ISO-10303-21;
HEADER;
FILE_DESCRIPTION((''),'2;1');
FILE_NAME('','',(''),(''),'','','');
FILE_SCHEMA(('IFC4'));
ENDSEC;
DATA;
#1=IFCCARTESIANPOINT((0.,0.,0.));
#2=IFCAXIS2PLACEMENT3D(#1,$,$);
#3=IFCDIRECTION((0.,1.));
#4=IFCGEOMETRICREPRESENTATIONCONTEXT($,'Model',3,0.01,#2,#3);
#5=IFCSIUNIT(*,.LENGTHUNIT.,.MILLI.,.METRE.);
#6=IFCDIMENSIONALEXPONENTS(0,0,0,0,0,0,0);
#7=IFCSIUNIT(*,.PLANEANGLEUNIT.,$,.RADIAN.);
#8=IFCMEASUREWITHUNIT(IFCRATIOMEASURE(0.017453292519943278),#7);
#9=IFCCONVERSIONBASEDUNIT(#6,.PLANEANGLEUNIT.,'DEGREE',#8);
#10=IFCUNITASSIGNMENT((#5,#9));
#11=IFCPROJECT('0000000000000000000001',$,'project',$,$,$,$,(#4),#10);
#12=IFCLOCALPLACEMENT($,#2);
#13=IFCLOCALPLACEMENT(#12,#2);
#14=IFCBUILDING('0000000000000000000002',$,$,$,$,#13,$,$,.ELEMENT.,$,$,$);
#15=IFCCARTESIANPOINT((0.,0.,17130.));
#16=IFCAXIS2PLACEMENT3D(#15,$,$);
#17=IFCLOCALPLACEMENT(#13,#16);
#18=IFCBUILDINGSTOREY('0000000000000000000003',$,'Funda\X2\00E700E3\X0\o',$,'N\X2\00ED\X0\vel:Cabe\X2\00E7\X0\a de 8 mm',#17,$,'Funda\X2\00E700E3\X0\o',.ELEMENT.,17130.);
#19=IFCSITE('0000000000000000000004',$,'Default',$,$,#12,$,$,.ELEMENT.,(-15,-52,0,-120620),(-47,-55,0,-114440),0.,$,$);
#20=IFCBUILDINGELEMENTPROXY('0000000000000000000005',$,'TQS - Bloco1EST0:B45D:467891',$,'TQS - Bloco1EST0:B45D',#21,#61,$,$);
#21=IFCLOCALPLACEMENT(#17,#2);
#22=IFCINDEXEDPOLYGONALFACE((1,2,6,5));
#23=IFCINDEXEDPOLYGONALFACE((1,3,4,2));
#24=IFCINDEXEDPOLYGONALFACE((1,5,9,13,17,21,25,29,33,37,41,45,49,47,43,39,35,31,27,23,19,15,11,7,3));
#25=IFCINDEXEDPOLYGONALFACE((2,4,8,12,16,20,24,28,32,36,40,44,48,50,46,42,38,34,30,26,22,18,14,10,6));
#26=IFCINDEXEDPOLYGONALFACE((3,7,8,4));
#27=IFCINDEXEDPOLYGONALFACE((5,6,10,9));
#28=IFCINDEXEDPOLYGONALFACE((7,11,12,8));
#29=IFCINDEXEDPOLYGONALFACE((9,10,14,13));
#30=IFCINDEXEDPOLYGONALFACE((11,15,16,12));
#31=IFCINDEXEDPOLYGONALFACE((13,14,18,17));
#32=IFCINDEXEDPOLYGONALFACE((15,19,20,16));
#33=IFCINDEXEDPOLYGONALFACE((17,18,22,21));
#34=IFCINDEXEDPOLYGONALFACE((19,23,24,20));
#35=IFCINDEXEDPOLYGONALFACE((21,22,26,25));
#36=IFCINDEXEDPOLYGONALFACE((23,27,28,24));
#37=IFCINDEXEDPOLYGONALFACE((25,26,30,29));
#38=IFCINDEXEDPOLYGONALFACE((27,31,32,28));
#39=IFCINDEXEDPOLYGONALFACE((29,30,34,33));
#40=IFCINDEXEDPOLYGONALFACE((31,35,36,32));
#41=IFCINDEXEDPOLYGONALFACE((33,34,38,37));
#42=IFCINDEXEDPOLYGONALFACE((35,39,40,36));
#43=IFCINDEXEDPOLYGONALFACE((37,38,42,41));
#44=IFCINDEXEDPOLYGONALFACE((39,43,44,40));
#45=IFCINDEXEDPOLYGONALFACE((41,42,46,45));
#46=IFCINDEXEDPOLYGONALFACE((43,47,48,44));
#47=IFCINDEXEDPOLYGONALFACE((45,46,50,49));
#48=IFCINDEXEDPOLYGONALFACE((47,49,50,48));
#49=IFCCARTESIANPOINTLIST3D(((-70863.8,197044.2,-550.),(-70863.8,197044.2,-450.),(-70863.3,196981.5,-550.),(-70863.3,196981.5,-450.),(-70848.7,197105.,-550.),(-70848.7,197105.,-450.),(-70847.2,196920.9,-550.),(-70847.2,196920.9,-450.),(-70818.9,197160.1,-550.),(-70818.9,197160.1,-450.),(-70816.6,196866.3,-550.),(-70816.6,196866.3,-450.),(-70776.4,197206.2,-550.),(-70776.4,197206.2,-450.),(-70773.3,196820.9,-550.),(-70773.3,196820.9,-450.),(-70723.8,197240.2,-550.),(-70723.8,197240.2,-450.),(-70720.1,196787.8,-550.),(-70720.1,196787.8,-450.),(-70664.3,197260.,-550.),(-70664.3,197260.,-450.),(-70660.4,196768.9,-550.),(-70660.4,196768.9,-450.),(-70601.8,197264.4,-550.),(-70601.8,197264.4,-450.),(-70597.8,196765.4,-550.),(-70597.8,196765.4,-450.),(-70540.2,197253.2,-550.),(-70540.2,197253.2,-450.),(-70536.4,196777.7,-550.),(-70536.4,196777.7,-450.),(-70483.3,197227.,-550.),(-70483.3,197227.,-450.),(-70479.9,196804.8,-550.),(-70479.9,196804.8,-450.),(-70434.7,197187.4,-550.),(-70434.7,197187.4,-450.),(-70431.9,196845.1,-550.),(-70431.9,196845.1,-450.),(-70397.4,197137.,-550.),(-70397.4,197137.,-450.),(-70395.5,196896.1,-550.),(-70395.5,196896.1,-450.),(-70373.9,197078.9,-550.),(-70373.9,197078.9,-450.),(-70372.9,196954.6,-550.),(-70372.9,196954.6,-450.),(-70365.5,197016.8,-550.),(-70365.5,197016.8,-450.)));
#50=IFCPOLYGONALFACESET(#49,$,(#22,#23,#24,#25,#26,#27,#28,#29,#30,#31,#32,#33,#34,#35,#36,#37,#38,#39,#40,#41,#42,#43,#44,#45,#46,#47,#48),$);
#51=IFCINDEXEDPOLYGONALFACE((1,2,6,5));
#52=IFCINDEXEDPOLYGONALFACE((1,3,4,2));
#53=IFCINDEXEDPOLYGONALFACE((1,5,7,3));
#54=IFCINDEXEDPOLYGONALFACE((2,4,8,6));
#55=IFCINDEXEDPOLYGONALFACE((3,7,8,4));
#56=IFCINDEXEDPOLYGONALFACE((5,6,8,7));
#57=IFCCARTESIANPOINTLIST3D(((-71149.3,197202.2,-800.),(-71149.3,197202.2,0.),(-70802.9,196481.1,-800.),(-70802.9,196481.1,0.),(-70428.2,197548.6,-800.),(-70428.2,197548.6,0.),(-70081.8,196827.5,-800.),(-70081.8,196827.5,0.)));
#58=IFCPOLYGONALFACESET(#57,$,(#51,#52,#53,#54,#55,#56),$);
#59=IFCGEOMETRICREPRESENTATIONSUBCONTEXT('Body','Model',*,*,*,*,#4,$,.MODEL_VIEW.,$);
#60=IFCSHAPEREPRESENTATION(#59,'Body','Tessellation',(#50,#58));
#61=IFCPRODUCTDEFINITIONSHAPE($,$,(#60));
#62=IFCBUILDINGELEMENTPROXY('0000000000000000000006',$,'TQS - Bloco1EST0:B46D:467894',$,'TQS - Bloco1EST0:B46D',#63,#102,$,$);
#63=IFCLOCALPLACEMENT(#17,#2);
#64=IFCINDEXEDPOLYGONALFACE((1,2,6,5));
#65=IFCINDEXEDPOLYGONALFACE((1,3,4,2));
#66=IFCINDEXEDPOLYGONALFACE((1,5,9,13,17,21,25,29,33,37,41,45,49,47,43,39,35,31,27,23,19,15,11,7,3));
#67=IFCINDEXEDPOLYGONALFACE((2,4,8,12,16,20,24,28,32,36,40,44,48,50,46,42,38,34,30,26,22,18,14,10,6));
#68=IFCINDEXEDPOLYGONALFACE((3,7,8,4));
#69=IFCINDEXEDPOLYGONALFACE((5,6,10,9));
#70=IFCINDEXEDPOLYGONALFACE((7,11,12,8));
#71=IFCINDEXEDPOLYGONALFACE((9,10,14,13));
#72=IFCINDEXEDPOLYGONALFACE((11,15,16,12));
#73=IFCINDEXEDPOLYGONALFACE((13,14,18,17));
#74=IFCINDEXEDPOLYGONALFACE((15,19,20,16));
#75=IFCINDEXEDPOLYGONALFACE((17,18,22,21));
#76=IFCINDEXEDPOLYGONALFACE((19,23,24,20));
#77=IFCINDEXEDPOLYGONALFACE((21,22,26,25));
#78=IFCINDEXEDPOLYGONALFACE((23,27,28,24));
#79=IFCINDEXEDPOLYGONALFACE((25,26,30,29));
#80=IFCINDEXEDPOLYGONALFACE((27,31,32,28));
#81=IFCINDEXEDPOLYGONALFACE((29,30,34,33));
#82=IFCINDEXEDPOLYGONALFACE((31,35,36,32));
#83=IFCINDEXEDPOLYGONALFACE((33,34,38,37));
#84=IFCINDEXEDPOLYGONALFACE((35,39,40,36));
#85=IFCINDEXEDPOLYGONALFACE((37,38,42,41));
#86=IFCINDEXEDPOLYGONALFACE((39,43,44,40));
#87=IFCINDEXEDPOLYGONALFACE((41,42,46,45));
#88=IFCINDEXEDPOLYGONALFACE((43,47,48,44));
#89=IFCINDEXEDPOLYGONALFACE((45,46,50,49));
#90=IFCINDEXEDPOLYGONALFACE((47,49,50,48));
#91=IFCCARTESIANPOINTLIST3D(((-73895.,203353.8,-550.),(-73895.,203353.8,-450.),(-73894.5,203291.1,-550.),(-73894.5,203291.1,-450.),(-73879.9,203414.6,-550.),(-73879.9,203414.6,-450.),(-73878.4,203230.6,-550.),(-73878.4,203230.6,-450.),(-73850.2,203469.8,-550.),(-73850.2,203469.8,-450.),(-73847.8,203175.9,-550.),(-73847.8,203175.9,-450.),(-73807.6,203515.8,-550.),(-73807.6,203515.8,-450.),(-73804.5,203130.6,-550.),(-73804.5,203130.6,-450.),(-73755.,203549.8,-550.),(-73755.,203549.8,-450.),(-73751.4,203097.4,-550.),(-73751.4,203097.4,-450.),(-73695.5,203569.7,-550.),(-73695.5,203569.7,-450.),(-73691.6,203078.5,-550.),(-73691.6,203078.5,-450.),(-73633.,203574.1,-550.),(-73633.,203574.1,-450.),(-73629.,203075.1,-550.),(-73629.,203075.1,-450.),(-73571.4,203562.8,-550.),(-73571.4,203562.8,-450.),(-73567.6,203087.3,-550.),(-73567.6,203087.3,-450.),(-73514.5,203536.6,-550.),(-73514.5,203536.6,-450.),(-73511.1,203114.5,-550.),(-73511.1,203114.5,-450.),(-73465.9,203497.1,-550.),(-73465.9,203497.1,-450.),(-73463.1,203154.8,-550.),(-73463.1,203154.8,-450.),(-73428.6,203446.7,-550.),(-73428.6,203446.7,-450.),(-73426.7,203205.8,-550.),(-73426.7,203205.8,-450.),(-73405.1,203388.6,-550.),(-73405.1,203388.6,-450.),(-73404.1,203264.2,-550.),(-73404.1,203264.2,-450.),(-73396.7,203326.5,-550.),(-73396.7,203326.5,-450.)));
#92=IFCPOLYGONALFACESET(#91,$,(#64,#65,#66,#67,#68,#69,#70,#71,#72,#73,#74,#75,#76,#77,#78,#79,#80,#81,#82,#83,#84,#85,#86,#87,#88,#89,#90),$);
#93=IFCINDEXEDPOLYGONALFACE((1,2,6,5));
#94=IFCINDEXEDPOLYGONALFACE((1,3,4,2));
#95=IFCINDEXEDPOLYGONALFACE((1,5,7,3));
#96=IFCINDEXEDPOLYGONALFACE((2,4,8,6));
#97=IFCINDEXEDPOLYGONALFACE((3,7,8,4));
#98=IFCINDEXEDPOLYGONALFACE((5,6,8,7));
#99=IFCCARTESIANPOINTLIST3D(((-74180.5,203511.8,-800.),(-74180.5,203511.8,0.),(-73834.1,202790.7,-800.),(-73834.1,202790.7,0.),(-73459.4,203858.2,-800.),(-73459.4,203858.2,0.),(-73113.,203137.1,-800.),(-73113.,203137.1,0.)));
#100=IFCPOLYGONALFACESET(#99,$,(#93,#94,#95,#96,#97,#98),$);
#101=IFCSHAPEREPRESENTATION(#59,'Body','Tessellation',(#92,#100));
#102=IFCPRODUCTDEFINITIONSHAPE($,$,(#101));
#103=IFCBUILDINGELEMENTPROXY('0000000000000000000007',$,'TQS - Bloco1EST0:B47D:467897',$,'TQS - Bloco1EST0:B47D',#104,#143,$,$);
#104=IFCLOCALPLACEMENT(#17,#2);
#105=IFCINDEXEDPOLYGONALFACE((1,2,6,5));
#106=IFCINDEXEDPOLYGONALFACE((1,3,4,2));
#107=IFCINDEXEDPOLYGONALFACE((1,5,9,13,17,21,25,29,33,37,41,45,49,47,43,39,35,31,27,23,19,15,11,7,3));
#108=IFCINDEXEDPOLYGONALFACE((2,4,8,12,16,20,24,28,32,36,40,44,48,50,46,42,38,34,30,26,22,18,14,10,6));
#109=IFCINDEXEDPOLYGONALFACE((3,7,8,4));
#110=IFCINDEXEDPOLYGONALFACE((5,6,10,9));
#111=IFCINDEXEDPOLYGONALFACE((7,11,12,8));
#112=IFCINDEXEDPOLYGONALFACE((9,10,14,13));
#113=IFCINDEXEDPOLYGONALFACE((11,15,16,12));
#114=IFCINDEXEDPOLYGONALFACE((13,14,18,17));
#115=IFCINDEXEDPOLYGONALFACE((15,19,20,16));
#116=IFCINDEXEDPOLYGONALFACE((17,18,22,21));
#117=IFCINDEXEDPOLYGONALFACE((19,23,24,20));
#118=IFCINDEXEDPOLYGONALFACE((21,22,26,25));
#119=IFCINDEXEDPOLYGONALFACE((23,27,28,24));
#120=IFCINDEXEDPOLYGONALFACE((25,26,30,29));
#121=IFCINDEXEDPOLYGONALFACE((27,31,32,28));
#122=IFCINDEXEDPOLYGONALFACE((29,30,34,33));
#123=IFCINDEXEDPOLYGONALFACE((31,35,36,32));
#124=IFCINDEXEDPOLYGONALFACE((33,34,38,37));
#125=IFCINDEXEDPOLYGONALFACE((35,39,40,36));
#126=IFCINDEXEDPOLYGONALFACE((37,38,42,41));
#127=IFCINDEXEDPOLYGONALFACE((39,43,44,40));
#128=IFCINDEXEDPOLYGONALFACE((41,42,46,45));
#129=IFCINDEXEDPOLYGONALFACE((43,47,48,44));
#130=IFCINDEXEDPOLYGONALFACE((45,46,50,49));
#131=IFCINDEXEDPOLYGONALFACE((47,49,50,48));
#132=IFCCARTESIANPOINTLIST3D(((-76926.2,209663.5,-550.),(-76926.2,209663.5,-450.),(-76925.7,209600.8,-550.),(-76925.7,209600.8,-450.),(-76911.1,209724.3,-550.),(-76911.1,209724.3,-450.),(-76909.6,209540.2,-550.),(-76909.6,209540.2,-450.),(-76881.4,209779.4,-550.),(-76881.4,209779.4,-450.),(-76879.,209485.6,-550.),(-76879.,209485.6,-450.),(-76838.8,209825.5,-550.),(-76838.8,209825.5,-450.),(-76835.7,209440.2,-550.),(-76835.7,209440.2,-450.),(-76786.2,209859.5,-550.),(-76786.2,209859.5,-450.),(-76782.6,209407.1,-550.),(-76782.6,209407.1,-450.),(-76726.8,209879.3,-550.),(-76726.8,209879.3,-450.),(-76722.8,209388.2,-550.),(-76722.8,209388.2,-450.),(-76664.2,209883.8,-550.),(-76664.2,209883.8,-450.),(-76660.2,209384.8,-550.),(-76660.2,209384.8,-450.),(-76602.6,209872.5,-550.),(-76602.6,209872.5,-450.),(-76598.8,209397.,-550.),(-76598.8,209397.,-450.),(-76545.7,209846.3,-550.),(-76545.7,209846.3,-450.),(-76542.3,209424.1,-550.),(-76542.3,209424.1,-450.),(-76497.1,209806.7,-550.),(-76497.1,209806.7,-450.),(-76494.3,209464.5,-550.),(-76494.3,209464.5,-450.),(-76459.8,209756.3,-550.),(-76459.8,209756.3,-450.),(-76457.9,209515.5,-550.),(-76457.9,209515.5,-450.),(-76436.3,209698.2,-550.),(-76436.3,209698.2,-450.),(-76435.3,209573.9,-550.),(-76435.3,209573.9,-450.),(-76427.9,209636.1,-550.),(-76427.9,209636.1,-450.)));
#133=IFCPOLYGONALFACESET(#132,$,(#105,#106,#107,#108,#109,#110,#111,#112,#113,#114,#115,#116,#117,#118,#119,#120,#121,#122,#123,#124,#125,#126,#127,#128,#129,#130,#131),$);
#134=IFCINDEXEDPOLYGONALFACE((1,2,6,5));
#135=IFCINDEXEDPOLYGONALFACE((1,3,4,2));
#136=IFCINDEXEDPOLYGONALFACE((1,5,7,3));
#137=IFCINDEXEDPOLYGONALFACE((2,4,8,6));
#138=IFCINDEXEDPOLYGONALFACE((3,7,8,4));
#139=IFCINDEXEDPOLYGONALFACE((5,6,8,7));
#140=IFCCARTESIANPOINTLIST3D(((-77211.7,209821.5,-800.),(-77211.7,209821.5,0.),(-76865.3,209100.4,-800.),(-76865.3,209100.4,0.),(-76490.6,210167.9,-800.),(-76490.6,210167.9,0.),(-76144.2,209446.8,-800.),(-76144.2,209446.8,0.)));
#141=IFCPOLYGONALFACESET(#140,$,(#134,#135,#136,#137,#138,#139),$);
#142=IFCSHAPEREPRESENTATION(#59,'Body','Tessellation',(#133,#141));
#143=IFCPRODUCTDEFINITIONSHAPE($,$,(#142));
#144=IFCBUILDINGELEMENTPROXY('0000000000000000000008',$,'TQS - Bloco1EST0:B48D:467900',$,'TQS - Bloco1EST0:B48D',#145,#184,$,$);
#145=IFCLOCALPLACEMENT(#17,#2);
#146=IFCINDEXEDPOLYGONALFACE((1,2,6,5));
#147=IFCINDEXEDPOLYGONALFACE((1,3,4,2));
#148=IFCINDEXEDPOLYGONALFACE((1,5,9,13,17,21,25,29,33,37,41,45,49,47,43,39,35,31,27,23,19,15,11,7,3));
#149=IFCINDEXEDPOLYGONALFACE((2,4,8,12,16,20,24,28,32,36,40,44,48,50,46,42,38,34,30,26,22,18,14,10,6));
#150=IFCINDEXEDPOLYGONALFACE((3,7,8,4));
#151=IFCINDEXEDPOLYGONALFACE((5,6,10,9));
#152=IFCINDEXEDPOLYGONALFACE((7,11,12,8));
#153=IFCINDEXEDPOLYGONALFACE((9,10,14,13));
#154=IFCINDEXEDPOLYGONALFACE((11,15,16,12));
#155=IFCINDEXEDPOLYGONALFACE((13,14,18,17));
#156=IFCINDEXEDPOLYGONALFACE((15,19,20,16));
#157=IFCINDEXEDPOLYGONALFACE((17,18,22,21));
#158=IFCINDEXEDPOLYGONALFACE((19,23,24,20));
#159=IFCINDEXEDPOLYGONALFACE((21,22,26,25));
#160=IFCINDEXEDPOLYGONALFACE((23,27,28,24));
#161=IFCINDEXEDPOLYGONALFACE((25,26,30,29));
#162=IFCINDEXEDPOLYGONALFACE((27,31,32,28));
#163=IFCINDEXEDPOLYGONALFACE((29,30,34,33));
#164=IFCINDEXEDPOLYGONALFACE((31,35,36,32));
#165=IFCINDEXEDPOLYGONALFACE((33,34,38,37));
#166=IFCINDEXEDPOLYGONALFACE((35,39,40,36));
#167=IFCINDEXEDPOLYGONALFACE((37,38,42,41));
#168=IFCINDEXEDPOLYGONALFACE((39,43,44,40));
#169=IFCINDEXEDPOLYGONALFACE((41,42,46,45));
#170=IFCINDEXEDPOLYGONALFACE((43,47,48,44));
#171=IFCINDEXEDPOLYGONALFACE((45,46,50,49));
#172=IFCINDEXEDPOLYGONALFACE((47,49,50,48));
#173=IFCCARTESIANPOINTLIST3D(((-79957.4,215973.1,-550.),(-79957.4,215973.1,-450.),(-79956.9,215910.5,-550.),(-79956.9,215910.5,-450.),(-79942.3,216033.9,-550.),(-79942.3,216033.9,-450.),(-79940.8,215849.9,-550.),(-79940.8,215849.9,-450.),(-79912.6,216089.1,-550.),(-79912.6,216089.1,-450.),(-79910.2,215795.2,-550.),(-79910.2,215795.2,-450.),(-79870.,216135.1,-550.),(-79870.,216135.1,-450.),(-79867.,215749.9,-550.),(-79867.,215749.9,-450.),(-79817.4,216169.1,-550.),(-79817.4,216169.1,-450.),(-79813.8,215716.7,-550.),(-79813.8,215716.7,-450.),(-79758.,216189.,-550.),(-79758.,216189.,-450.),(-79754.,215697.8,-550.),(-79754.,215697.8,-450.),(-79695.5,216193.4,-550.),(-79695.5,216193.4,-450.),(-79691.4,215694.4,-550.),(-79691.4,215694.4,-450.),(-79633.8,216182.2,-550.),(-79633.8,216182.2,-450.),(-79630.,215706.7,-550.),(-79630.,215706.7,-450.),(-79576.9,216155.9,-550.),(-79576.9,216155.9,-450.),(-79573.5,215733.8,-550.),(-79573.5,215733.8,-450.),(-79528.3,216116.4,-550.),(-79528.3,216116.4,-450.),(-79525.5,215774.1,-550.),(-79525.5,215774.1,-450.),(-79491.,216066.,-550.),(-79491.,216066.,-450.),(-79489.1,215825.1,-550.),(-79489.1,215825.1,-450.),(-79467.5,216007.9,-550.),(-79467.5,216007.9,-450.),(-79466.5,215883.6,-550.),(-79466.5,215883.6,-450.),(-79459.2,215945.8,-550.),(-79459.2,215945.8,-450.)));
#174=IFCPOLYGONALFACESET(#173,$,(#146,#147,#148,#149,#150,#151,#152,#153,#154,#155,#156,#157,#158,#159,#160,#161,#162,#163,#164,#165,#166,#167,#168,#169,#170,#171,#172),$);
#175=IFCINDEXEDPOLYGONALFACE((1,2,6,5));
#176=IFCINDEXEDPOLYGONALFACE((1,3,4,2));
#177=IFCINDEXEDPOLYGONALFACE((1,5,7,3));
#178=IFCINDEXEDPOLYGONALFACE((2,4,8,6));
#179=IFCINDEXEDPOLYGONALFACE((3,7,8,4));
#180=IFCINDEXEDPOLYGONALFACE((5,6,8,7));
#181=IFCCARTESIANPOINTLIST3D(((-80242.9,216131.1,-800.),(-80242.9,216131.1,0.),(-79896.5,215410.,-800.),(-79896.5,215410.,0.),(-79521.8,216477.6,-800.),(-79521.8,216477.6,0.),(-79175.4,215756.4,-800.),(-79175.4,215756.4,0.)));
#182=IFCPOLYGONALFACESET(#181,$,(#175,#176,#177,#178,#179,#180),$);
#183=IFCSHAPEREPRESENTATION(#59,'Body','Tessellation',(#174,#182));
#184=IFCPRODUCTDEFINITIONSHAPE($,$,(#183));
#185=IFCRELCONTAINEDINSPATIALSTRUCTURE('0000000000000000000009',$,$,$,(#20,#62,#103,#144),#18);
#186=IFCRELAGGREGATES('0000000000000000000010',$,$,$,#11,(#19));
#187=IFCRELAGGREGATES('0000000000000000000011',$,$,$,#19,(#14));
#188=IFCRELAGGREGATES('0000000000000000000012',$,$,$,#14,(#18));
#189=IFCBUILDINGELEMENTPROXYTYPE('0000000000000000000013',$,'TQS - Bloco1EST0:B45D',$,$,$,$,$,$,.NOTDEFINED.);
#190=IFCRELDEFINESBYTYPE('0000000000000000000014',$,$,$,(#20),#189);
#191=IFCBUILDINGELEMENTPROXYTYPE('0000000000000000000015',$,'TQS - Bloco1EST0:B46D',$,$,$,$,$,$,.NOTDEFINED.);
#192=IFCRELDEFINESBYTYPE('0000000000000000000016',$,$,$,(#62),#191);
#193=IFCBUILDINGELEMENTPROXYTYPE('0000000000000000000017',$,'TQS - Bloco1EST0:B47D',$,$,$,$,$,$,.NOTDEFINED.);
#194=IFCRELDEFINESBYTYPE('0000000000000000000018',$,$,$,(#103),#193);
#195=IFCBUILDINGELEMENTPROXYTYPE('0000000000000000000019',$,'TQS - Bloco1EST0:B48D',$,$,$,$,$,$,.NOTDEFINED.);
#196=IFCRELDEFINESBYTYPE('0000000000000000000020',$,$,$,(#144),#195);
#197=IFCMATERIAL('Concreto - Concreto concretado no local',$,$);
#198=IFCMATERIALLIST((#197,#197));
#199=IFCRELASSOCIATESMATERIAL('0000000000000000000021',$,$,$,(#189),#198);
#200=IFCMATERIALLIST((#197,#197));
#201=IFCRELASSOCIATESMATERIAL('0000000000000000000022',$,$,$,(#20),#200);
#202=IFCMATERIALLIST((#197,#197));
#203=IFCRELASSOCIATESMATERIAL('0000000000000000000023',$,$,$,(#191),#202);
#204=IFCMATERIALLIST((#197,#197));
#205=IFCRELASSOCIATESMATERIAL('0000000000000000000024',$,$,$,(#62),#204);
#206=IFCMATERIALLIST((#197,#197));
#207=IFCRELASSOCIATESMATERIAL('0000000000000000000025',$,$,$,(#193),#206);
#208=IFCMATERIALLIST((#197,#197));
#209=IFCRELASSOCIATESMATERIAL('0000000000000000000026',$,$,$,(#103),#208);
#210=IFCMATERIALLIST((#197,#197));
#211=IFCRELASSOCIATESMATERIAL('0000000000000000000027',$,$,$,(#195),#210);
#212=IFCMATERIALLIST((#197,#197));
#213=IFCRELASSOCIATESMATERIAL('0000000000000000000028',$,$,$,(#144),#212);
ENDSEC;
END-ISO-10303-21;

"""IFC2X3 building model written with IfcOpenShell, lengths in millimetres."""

from ifc_helpers import new_model, entity, si_unit, converted_unit, direction, frame, frame_2d, origin, origin_2d_with_axis, place, context, subcontext, project, spatial, rectangle, circle, extrude, source, transform, mapped, material, material_list, type_object, type_shapes, element, save


model = new_model("IFC2X3")

# Units and contexts
model_context = context("Model", 3, precision=0.01, world=origin(), true_north=direction((0.0, 1.0)))
body_context = subcontext(model_context, "Body", "Model", "MODEL_VIEW")
ifc_project = project(units=[si_unit("LENGTHUNIT", "METRE", prefix="MILLI"), converted_unit("PLANEANGLEUNIT", "DEGREE", entity("IfcRatioMeasure", 0.017453292519943278), si_unit("PLANEANGLEUNIT", "RADIAN"), dimensions=[0, 0, 0, 0, 0, 0, 0])], contexts=[model_context])

# Site, building, storey
site_placement = place(None, origin())
site = spatial("IfcSite", under=ifc_project, at=site_placement, Name="Default", CompositionType="ELEMENT", RefLatitude=(-15, -52, 0, -120620), RefLongitude=(-47, -55, 0, -114440), RefElevation=0.0)
building_placement = place(site_placement, origin())
building = spatial("IfcBuilding", under=site, at=building_placement, CompositionType="ELEMENT")
storey_placement = place(building_placement, frame((0.0, 0.0, 17130.0)))
storey = spatial("IfcBuildingStorey", under=building, at=storey_placement, Name="Fundação", ObjectType="Nível:Cabeça de 8 mm", LongName="Fundação", CompositionType="ELEMENT", Elevation=17130.0)

# Building element proxies
ifc_material_1 = material(Name="Concreto - Concreto concretado no local")
ifc_material_list_1 = material_list([ifc_material_1, ifc_material_1])
ifc_material_list_2 = material_list([ifc_material_1, ifc_material_1])
building_element_proxy_type_1 = type_object("IfcBuildingElementProxyType", Name="TQS - Bloco1EST0:B45D", PredefinedType="NOTDEFINED", material=ifc_material_list_2)
shared_shape_1 = source(origin(), body_context, "Body", "SweptSolid", [
    extrude(circle(Radius=250.0, at=frame_2d((0.0, 0.0), x_axis=(1.0, 0.0))), frame((0.0, 0.0, -550.0)), (0.0, 0.0, 1.0), 100.0),
    extrude(rectangle(XDim=800.0, YDim=800.0, at=origin_2d_with_axis()), frame((0.0, 0.0, -800.0), z_axis=(0.0, 0.0, 1.0), x_axis=(-1.0, 0.0, 0.0)), (0.0, 0.0, 1.0), 800.0),
])
type_shapes(building_element_proxy_type_1, [shared_shape_1])
proxy_1_placement = place(storey_placement, frame((-70615.5, 197014.8, 0.0), z_axis=(0.0, 0.0, 1.0), x_axis=(-0.43303, 0.90138, 0.0)))
element("IfcBuildingElementProxy", 1, at=proxy_1_placement, inside=storey, type_object=building_element_proxy_type_1, material=ifc_material_list_1, Name="TQS - Bloco1EST0:B45D:467891", ObjectType="TQS - Bloco1EST0:B45D", context=body_context, shape_type="MappedRepresentation", body=[
    mapped(shared_shape_1, transform((0.0, 0.0, 0.0), scale=1.0)),
])
ifc_material_list_3 = material_list([ifc_material_1, ifc_material_1])
ifc_material_list_4 = material_list([ifc_material_1, ifc_material_1])
building_element_proxy_type_2 = type_object("IfcBuildingElementProxyType", Name="TQS - Bloco1EST0:B46D", PredefinedType="NOTDEFINED", material=ifc_material_list_4)
shared_shape_2 = source(origin(), body_context, "Body", "SweptSolid", [
    extrude(circle(Radius=250.0, at=frame_2d((0.0, 0.0), x_axis=(1.0, 0.0))), frame((0.0, 0.0, -550.0)), (0.0, 0.0, 1.0), 100.0),
    extrude(rectangle(XDim=800.0, YDim=800.0, at=origin_2d_with_axis()), frame((0.0, 0.0, -800.0), z_axis=(0.0, 0.0, 1.0), x_axis=(-1.0, 0.0, 0.0)), (0.0, 0.0, 1.0), 800.0),
])
type_shapes(building_element_proxy_type_2, [shared_shape_2])
proxy_2_placement = place(storey_placement, frame((-73646.7, 203324.5, 0.0), z_axis=(0.0, 0.0, 1.0), x_axis=(-0.43303, 0.90138, 0.0)))
element("IfcBuildingElementProxy", 2, at=proxy_2_placement, inside=storey, type_object=building_element_proxy_type_2, material=ifc_material_list_3, Name="TQS - Bloco1EST0:B46D:467894", ObjectType="TQS - Bloco1EST0:B46D", context=body_context, shape_type="MappedRepresentation", body=[
    mapped(shared_shape_2, transform((0.0, 0.0, 0.0), scale=1.0)),
])
ifc_material_list_5 = material_list([ifc_material_1, ifc_material_1])
ifc_material_list_6 = material_list([ifc_material_1, ifc_material_1])
building_element_proxy_type_3 = type_object("IfcBuildingElementProxyType", Name="TQS - Bloco1EST0:B47D", PredefinedType="NOTDEFINED", material=ifc_material_list_6)
shared_shape_3 = source(origin(), body_context, "Body", "SweptSolid", [
    extrude(circle(Radius=250.0, at=frame_2d((0.0, 0.0), x_axis=(1.0, 0.0))), frame((0.0, 0.0, -550.0)), (0.0, 0.0, 1.0), 100.0),
    extrude(rectangle(XDim=800.0, YDim=800.0, at=origin_2d_with_axis()), frame((0.0, 0.0, -800.0), z_axis=(0.0, 0.0, 1.0), x_axis=(-1.0, 0.0, 0.0)), (0.0, 0.0, 1.0), 800.0),
])
type_shapes(building_element_proxy_type_3, [shared_shape_3])
proxy_3_placement = place(storey_placement, frame((-76677.9, 209634.1, 0.0), z_axis=(0.0, 0.0, 1.0), x_axis=(-0.43303, 0.90138, 0.0)))
element("IfcBuildingElementProxy", 3, at=proxy_3_placement, inside=storey, type_object=building_element_proxy_type_3, material=ifc_material_list_5, Name="TQS - Bloco1EST0:B47D:467897", ObjectType="TQS - Bloco1EST0:B47D", context=body_context, shape_type="MappedRepresentation", body=[
    mapped(shared_shape_3, transform((0.0, 0.0, 0.0), scale=1.0)),
])
ifc_material_list_7 = material_list([ifc_material_1, ifc_material_1])
ifc_material_list_8 = material_list([ifc_material_1, ifc_material_1])
building_element_proxy_type_4 = type_object("IfcBuildingElementProxyType", Name="TQS - Bloco1EST0:B48D", PredefinedType="NOTDEFINED", material=ifc_material_list_8)
shared_shape_4 = source(origin(), body_context, "Body", "SweptSolid", [
    extrude(circle(Radius=250.0, at=frame_2d((0.0, 0.0), x_axis=(1.0, 0.0))), frame((0.0, 0.0, -550.0)), (0.0, 0.0, 1.0), 100.0),
    extrude(rectangle(XDim=800.0, YDim=800.0, at=origin_2d_with_axis()), frame((0.0, 0.0, -800.0), z_axis=(0.0, 0.0, 1.0), x_axis=(-1.0, 0.0, 0.0)), (0.0, 0.0, 1.0), 800.0),
])
type_shapes(building_element_proxy_type_4, [shared_shape_4])
proxy_4_placement = place(storey_placement, frame((-79709.2, 215943.8, 0.0), z_axis=(0.0, 0.0, 1.0), x_axis=(-0.43303, 0.90138, 0.0)))
element("IfcBuildingElementProxy", 4, at=proxy_4_placement, inside=storey, type_object=building_element_proxy_type_4, material=ifc_material_list_7, Name="TQS - Bloco1EST0:B48D:467900", ObjectType="TQS - Bloco1EST0:B48D", context=body_context, shape_type="MappedRepresentation", body=[
    mapped(shared_shape_4, transform((0.0, 0.0, 0.0), scale=1.0)),
])

save(model, "model.ifc")
